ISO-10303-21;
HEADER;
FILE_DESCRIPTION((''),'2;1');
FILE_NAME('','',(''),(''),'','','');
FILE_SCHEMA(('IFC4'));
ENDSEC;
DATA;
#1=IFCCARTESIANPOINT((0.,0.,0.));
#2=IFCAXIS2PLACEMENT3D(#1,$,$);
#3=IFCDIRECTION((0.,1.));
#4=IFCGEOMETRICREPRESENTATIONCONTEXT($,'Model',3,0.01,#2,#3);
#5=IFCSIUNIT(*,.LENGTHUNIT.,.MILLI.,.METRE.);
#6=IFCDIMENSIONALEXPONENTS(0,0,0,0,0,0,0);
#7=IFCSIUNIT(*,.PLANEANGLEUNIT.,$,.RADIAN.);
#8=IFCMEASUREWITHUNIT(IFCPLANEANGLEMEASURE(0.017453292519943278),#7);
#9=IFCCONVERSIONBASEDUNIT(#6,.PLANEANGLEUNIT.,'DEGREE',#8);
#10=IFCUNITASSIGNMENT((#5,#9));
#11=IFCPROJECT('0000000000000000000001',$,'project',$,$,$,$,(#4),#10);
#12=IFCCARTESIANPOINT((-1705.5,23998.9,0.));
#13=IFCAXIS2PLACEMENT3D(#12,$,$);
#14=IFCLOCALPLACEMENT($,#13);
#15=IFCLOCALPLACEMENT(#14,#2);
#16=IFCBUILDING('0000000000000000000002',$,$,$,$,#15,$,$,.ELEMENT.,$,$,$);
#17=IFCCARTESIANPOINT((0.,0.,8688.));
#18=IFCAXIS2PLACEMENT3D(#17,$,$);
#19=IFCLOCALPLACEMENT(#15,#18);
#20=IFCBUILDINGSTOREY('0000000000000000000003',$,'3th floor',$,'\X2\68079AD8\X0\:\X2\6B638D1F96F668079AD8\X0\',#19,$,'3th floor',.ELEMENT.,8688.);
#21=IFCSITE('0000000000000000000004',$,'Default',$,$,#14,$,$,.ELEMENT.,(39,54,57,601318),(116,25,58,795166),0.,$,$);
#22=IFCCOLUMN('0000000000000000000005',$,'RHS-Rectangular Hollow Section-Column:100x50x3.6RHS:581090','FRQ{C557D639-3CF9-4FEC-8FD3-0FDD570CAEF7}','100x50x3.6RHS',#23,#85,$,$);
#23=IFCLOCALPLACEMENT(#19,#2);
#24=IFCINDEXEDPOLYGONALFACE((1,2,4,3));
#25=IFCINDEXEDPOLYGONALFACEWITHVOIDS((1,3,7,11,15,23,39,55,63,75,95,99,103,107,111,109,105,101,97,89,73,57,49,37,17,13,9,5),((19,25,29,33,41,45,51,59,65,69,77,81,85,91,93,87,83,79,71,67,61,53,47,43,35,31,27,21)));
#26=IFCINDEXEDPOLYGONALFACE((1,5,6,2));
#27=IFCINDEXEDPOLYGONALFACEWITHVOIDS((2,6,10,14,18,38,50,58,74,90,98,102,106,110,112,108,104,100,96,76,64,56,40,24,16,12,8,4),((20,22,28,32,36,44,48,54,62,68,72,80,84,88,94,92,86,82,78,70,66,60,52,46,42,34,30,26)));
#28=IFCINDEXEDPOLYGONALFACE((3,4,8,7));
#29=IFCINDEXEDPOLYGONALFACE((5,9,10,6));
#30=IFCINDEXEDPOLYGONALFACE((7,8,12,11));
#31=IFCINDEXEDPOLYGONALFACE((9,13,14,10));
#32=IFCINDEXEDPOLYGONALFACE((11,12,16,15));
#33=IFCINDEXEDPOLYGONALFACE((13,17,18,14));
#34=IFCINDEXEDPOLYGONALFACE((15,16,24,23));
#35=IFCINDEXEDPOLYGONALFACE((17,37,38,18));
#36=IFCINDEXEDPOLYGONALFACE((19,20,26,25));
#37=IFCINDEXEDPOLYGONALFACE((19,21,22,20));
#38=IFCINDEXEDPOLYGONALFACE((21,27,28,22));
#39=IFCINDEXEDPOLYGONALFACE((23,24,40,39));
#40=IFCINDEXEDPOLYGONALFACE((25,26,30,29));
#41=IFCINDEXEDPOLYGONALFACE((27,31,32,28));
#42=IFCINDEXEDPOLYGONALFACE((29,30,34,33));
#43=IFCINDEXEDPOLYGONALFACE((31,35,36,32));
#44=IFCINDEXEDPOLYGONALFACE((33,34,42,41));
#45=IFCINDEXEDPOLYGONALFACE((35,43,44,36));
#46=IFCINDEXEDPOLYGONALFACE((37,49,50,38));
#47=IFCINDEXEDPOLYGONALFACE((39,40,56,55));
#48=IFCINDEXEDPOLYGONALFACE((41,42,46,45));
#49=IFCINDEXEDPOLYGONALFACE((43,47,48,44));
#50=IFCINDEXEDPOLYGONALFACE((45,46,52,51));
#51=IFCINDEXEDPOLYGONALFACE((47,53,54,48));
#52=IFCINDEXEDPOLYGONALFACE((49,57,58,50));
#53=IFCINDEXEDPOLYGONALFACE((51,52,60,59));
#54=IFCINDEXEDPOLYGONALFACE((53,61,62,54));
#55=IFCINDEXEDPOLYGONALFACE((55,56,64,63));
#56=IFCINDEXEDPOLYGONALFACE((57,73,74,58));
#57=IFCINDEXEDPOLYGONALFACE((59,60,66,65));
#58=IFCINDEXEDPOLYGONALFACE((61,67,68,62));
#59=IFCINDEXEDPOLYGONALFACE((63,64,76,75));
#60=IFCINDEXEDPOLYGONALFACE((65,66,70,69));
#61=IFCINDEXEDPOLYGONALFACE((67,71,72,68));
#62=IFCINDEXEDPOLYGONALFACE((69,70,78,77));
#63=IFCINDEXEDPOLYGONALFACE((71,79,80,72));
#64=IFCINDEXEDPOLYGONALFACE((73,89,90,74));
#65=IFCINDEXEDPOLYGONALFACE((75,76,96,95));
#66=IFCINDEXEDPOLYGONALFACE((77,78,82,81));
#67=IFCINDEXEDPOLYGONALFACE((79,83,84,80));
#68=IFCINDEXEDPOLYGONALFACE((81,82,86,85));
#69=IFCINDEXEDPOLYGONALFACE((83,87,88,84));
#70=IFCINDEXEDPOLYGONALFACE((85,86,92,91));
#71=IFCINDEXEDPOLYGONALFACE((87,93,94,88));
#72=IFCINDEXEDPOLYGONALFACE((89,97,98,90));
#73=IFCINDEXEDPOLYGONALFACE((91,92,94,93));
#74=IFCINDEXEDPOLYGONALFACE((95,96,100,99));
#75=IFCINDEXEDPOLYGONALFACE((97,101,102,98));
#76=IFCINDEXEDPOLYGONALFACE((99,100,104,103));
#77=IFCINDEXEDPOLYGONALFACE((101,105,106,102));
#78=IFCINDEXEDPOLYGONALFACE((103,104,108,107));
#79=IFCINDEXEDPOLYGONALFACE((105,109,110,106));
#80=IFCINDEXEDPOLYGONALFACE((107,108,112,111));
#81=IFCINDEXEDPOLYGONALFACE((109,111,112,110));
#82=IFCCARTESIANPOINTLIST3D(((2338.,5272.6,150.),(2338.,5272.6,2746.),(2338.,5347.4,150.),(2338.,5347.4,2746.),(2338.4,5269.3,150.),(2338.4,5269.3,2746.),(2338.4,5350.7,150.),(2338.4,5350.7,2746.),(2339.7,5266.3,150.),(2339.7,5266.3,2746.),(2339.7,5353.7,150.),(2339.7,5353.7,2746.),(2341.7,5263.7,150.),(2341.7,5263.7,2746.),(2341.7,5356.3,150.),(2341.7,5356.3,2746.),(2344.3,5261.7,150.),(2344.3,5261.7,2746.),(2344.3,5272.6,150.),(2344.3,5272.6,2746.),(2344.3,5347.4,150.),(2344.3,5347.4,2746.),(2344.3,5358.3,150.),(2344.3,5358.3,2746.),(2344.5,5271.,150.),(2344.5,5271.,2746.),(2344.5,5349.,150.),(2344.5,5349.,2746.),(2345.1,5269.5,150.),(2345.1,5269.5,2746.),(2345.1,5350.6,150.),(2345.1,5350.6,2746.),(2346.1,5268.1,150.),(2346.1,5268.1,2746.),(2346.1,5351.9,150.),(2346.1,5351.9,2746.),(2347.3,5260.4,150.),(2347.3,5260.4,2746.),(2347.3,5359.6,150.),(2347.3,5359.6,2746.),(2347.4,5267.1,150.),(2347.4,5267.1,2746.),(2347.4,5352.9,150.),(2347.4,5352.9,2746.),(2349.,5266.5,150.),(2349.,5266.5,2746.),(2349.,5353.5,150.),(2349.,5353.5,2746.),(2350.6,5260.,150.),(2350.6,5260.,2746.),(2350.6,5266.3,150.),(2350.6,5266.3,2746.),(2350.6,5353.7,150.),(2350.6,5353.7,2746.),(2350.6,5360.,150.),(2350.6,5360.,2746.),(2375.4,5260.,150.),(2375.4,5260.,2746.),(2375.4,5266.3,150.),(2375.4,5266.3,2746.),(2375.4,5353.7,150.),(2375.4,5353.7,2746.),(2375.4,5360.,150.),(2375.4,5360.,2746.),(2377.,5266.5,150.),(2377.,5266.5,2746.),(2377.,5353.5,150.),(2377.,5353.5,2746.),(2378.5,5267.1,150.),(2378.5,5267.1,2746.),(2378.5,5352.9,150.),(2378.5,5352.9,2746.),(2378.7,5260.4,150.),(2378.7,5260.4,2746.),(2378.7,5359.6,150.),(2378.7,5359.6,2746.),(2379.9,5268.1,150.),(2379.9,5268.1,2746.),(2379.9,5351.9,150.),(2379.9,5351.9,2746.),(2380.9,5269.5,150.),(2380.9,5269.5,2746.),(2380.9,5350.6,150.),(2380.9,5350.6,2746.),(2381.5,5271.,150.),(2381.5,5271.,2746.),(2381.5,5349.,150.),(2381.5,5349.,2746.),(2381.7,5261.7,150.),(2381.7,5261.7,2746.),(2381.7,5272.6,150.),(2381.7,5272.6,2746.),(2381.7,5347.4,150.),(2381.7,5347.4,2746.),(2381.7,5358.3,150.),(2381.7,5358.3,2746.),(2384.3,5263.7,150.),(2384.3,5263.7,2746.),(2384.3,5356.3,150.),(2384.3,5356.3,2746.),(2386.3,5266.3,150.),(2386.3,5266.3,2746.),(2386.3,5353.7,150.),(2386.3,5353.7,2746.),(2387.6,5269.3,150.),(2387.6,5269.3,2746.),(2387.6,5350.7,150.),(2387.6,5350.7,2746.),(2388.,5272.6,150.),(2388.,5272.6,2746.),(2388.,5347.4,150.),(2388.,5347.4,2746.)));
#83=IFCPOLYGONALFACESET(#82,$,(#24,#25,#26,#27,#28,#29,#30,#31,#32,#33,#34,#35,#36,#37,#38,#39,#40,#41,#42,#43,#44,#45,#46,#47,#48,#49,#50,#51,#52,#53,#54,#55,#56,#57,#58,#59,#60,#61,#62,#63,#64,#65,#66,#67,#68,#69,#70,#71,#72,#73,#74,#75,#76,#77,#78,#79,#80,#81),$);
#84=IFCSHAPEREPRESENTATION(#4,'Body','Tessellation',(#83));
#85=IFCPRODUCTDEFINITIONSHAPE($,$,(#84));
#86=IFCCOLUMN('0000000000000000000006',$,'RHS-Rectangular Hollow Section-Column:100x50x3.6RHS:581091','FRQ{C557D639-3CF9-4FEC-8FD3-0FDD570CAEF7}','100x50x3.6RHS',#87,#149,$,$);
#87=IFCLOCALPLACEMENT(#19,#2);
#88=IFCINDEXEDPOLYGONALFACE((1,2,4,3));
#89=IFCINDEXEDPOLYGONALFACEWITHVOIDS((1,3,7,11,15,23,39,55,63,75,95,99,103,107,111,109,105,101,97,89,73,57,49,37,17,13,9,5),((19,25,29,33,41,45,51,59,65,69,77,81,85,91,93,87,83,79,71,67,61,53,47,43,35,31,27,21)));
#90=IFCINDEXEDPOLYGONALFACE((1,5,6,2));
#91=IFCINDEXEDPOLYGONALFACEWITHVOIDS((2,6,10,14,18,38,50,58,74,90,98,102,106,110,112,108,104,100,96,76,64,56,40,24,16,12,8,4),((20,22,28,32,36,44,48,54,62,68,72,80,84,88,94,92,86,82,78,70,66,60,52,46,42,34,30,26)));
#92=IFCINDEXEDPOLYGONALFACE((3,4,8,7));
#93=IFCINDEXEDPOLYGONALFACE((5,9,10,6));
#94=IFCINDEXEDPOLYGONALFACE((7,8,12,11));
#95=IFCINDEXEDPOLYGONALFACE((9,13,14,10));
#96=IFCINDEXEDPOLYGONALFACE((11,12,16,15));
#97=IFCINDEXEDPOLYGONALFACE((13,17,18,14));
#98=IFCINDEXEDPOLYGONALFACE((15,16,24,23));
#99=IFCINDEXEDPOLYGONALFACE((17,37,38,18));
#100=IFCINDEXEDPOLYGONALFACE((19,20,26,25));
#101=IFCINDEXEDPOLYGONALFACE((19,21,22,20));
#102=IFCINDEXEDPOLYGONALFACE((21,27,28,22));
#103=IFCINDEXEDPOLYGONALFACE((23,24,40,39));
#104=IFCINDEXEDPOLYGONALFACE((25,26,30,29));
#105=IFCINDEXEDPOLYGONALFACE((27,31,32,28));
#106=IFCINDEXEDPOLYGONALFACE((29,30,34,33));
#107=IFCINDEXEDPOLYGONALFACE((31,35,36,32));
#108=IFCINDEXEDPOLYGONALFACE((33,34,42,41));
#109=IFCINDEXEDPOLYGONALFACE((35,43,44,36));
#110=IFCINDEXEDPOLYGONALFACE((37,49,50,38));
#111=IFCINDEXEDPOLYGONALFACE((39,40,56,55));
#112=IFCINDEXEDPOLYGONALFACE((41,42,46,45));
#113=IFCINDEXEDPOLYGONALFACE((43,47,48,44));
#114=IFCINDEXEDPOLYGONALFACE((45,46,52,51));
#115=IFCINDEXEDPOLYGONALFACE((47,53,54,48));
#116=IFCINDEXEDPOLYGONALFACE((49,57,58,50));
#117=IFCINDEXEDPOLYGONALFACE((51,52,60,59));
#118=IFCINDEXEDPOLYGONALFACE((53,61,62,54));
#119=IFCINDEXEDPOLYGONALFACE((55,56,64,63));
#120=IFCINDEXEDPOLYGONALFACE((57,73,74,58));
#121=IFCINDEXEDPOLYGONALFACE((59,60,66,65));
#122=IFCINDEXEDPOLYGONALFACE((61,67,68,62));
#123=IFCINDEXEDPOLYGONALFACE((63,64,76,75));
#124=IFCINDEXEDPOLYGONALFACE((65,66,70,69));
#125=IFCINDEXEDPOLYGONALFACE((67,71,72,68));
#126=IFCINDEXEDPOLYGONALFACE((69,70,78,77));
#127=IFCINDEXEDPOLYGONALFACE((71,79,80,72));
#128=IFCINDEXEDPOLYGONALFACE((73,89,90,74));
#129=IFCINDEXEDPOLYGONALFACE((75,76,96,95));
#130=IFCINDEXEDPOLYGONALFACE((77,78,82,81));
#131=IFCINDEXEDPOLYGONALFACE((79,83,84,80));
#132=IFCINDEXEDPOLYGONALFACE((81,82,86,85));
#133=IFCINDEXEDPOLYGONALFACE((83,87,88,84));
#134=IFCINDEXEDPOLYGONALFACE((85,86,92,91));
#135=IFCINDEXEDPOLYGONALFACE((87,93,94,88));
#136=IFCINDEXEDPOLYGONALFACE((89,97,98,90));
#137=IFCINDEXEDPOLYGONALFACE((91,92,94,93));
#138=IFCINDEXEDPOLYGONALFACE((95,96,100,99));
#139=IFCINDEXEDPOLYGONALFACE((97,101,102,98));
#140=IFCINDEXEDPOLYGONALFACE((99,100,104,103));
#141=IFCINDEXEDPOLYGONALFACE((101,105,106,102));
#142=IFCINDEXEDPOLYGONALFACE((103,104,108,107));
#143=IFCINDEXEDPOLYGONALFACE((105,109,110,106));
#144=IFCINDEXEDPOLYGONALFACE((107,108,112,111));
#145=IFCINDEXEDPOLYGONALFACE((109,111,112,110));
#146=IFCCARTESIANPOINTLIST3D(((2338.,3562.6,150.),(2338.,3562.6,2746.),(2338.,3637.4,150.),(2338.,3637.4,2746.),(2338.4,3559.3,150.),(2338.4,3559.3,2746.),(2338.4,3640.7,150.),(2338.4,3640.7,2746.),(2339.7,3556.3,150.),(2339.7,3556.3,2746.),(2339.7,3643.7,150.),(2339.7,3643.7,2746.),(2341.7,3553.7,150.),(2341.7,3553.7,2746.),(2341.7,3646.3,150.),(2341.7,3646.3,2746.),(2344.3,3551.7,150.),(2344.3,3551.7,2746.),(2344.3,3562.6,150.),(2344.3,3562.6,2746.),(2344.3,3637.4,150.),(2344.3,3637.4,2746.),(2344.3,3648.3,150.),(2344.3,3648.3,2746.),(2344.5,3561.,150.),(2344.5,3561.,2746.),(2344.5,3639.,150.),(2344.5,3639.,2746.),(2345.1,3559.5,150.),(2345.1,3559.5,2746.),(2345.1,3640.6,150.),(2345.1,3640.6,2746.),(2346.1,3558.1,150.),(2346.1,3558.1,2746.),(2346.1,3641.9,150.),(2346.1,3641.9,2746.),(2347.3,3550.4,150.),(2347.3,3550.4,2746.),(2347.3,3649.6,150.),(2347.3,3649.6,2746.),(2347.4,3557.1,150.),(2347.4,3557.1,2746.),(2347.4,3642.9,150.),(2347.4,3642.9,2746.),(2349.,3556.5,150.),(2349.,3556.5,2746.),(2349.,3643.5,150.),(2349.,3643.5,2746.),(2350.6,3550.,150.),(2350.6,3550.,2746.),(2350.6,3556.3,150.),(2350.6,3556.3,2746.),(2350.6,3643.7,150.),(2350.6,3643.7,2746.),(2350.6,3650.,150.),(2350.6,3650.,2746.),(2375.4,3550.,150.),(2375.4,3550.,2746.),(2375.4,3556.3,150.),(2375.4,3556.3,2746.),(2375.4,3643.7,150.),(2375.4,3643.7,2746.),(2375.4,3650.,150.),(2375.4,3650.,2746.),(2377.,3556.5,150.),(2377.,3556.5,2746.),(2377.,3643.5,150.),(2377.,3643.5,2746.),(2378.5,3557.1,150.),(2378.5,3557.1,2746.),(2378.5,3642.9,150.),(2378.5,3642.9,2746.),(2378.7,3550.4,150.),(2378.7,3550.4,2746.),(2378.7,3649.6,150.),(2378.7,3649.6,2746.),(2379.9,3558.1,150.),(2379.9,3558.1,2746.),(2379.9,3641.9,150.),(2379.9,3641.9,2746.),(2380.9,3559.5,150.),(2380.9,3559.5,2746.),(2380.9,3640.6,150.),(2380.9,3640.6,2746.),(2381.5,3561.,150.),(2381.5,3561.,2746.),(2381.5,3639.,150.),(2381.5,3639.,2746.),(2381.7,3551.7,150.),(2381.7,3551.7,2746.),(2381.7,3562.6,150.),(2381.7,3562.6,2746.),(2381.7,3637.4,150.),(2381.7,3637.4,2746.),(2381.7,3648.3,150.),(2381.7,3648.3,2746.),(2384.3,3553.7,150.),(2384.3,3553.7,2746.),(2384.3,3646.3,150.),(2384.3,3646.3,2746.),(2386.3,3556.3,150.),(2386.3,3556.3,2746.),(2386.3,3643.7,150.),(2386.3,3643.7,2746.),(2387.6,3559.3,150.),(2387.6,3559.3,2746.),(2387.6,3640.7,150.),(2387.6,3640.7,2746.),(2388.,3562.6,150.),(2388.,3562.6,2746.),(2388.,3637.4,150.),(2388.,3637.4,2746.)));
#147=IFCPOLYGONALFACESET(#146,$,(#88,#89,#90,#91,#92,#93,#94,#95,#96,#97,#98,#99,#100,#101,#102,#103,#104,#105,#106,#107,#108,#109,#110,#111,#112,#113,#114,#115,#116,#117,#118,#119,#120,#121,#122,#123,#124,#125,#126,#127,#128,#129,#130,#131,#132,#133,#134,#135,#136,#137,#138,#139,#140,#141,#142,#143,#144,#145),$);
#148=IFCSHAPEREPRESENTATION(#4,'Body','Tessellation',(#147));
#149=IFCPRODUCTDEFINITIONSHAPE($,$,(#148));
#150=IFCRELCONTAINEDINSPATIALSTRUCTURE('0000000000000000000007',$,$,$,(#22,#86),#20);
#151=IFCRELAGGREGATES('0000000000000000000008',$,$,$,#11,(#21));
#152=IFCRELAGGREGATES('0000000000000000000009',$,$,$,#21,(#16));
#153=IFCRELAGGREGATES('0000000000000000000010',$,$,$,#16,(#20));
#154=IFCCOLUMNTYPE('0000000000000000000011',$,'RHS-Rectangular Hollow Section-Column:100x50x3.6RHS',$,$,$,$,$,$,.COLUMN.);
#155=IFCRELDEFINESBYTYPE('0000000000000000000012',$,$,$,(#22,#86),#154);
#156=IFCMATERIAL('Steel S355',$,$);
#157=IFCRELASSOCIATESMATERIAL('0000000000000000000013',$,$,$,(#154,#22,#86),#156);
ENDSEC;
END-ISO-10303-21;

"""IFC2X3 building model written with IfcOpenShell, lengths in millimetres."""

from ifc_helpers import new_model, entity, si_unit, converted_unit, direction, frame, origin, origin_2d, place, context, project, spatial, hollow_rectangle, extrude, clip, halfspace, material, type_object, element, save


model = new_model("IFC2X3")

# Units and contexts
model_context = context("Model", 3, precision=0.01, world=origin(), true_north=direction((0.0, 1.0)))
ifc_project = project(units=[si_unit("LENGTHUNIT", "METRE", prefix="MILLI"), converted_unit("PLANEANGLEUNIT", "DEGREE", entity("IfcPlaneAngleMeasure", 0.017453292519943278), si_unit("PLANEANGLEUNIT", "RADIAN"), dimensions=[0, 0, 0, 0, 0, 0, 0])], contexts=[model_context])

# Site, building, storey
site_placement = place(None, frame((-1705.5, 23998.9, 0.0)))
site = spatial("IfcSite", under=ifc_project, at=site_placement, Name="Default", CompositionType="ELEMENT", RefLatitude=(39, 54, 57, 601318), RefLongitude=(116, 25, 58, 795166), RefElevation=0.0)
building_placement = place(site_placement, origin())
building = spatial("IfcBuilding", under=site, at=building_placement, CompositionType="ELEMENT")
storey_placement = place(building_placement, frame((0.0, 0.0, 8688.0)))
storey = spatial("IfcBuildingStorey", under=building, at=storey_placement, Name="3th floor", ObjectType="标高:正负零标高", LongName="3th floor", CompositionType="ELEMENT", Elevation=8688.0)

# Columns
ifc_material = material(Name="Steel S355")
column_type_1 = type_object("IfcColumnType", Name="RHS-Rectangular Hollow Section-Column:100x50x3.6RHS", PredefinedType="COLUMN", material=ifc_material)
column_1_placement = place(storey_placement, frame((2363.0, 5310.0, 2746.0), z_axis=(0.0, 0.0, 1.0), x_axis=(-1.0, 0.0, 0.0)))
element("IfcColumn", 1, at=column_1_placement, inside=storey, type_object=column_type_1, material=ifc_material, Name="RHS-Rectangular Hollow Section-Column:100x50x3.6RHS:581090", Description="FRQ{C557D639-3CF9-4FEC-8FD3-0FDD570CAEF7}", ObjectType="100x50x3.6RHS", context=model_context, shape_type="Clipping", body=[
    clip(extrude(hollow_rectangle(XDim=50.0, YDim=100.0, WallThickness=6.3, InnerFilletRadius=6.3, OuterFilletRadius=12.6, at=origin_2d()), origin(), (0.0, 0.0, -1.0), 2651.9), halfspace(frame((2363.0, 5310.0, -2596.0), z_axis=(0.0, 0.0, 1.0), x_axis=(-1.0, 0.0, 0.0)), True)),
])
column_2_placement = place(storey_placement, frame((2363.0, 3600.0, 2746.0), z_axis=(0.0, 0.0, 1.0), x_axis=(-1.0, 0.0, 0.0)))
element("IfcColumn", 2, at=column_2_placement, inside=storey, type_object=column_type_1, material=ifc_material, Name="RHS-Rectangular Hollow Section-Column:100x50x3.6RHS:581091", Description="FRQ{C557D639-3CF9-4FEC-8FD3-0FDD570CAEF7}", ObjectType="100x50x3.6RHS", context=model_context, shape_type="Clipping", body=[
    clip(extrude(hollow_rectangle(XDim=50.0, YDim=100.0, WallThickness=6.3, InnerFilletRadius=6.3, OuterFilletRadius=12.6, at=origin_2d()), origin(), (0.0, 0.0, -1.0), 2651.9), halfspace(frame((2363.0, 3600.0, -2596.0), z_axis=(0.0, 0.0, 1.0), x_axis=(-1.0, 0.0, 0.0)), True)),
])

save(model, "model.ifc")
